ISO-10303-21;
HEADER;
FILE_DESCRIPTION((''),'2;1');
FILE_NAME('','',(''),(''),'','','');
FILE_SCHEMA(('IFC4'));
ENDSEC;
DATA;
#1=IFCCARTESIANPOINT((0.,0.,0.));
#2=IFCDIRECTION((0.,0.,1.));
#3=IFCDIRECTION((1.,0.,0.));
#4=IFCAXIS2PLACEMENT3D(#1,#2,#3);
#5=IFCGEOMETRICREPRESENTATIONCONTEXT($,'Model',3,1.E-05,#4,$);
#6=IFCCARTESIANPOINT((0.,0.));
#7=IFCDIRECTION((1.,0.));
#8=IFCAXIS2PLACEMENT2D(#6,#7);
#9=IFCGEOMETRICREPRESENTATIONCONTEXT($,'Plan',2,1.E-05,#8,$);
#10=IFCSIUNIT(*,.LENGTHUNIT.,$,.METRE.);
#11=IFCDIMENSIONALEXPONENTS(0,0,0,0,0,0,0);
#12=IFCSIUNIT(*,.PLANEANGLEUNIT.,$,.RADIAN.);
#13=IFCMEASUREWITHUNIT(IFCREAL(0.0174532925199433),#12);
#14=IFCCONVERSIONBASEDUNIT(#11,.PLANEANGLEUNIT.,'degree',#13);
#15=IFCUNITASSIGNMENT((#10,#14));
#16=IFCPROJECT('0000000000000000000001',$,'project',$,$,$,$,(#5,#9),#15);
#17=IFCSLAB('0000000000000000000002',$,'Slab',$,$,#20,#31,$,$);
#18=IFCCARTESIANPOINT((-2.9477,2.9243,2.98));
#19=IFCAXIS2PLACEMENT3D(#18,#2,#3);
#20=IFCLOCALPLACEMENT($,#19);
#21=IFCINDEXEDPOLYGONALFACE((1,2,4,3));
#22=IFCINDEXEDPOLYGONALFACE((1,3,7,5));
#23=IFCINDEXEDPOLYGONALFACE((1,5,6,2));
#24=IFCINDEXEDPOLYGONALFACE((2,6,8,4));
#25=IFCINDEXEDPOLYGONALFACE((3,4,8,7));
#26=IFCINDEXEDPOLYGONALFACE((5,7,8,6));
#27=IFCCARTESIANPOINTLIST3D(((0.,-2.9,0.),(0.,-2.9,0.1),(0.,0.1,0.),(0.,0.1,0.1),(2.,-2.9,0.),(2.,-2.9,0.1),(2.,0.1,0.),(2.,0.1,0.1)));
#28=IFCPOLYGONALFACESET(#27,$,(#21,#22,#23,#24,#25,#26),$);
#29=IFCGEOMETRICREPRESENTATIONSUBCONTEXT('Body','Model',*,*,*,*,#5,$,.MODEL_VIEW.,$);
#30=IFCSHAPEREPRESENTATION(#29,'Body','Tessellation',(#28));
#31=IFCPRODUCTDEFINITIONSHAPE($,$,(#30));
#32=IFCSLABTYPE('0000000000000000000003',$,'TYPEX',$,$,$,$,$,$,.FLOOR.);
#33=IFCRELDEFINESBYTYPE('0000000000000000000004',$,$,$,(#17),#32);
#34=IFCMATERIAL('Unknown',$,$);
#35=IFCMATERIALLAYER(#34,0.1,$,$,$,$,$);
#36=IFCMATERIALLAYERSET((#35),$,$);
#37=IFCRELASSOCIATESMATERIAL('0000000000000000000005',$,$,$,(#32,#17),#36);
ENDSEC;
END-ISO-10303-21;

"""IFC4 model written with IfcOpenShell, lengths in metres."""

from ifc_helpers import new_model, entity, si_unit, converted_unit, frame, origin_with_axes, origin_2d_with_axis, place, context, subcontext, project, line, indexed_curve, outline, extrude, material, layer, layer_set, layer_usage, type_object, element, save


model = new_model("IFC4")

# Units and contexts
model_context = context("Model", 3, precision=1e-05, world=origin_with_axes())
plan_context = context("Plan", 2, precision=1e-05, world=origin_2d_with_axis())
body_context = subcontext(model_context, "Body", "Model", "MODEL_VIEW")
ifc_project = project(units=[si_unit("LENGTHUNIT", "METRE"), converted_unit("PLANEANGLEUNIT", "degree", entity("IfcReal", 0.0174532925199433), si_unit("PLANEANGLEUNIT", "RADIAN"), dimensions=[0, 0, 0, 0, 0, 0, 0])], contexts=[model_context, plan_context])

# Shared definitions
ifc_material = material(Name="Unknown")

# Slab
ifc_layer = layer(ifc_material, 0.1)
ifc_layer_set = layer_set([ifc_layer])
ifc_layer_usage = layer_usage(ifc_layer_set, "AXIS3", "POSITIVE", 0.0)
slab_type = type_object("IfcSlabType", Name="TYPEX", PredefinedType="FLOOR", material=ifc_layer_set)
slab_placement = place(None, frame((-2.9477, 2.9243, 2.98), z_axis=(0.0, 0.0, 1.0), x_axis=(1.0, 0.0, 0.0)))
element("IfcSlab", 1, at=slab_placement, type_object=slab_type, material=ifc_layer_usage, Name="Slab", context=body_context, shape_type="SweptSolid", body=[
    extrude(outline(indexed_curve([(0.0, -2.9), (2.0, -2.9), (2.0, 0.1), (0.0, 0.1)], segments=[line(4, 1), line(1, 2), line(2, 3), line(3, 4)], self_intersect=False)), None, (0.0, 0.0, 1.0), 0.1),
])

save(model, "model.ifc")
